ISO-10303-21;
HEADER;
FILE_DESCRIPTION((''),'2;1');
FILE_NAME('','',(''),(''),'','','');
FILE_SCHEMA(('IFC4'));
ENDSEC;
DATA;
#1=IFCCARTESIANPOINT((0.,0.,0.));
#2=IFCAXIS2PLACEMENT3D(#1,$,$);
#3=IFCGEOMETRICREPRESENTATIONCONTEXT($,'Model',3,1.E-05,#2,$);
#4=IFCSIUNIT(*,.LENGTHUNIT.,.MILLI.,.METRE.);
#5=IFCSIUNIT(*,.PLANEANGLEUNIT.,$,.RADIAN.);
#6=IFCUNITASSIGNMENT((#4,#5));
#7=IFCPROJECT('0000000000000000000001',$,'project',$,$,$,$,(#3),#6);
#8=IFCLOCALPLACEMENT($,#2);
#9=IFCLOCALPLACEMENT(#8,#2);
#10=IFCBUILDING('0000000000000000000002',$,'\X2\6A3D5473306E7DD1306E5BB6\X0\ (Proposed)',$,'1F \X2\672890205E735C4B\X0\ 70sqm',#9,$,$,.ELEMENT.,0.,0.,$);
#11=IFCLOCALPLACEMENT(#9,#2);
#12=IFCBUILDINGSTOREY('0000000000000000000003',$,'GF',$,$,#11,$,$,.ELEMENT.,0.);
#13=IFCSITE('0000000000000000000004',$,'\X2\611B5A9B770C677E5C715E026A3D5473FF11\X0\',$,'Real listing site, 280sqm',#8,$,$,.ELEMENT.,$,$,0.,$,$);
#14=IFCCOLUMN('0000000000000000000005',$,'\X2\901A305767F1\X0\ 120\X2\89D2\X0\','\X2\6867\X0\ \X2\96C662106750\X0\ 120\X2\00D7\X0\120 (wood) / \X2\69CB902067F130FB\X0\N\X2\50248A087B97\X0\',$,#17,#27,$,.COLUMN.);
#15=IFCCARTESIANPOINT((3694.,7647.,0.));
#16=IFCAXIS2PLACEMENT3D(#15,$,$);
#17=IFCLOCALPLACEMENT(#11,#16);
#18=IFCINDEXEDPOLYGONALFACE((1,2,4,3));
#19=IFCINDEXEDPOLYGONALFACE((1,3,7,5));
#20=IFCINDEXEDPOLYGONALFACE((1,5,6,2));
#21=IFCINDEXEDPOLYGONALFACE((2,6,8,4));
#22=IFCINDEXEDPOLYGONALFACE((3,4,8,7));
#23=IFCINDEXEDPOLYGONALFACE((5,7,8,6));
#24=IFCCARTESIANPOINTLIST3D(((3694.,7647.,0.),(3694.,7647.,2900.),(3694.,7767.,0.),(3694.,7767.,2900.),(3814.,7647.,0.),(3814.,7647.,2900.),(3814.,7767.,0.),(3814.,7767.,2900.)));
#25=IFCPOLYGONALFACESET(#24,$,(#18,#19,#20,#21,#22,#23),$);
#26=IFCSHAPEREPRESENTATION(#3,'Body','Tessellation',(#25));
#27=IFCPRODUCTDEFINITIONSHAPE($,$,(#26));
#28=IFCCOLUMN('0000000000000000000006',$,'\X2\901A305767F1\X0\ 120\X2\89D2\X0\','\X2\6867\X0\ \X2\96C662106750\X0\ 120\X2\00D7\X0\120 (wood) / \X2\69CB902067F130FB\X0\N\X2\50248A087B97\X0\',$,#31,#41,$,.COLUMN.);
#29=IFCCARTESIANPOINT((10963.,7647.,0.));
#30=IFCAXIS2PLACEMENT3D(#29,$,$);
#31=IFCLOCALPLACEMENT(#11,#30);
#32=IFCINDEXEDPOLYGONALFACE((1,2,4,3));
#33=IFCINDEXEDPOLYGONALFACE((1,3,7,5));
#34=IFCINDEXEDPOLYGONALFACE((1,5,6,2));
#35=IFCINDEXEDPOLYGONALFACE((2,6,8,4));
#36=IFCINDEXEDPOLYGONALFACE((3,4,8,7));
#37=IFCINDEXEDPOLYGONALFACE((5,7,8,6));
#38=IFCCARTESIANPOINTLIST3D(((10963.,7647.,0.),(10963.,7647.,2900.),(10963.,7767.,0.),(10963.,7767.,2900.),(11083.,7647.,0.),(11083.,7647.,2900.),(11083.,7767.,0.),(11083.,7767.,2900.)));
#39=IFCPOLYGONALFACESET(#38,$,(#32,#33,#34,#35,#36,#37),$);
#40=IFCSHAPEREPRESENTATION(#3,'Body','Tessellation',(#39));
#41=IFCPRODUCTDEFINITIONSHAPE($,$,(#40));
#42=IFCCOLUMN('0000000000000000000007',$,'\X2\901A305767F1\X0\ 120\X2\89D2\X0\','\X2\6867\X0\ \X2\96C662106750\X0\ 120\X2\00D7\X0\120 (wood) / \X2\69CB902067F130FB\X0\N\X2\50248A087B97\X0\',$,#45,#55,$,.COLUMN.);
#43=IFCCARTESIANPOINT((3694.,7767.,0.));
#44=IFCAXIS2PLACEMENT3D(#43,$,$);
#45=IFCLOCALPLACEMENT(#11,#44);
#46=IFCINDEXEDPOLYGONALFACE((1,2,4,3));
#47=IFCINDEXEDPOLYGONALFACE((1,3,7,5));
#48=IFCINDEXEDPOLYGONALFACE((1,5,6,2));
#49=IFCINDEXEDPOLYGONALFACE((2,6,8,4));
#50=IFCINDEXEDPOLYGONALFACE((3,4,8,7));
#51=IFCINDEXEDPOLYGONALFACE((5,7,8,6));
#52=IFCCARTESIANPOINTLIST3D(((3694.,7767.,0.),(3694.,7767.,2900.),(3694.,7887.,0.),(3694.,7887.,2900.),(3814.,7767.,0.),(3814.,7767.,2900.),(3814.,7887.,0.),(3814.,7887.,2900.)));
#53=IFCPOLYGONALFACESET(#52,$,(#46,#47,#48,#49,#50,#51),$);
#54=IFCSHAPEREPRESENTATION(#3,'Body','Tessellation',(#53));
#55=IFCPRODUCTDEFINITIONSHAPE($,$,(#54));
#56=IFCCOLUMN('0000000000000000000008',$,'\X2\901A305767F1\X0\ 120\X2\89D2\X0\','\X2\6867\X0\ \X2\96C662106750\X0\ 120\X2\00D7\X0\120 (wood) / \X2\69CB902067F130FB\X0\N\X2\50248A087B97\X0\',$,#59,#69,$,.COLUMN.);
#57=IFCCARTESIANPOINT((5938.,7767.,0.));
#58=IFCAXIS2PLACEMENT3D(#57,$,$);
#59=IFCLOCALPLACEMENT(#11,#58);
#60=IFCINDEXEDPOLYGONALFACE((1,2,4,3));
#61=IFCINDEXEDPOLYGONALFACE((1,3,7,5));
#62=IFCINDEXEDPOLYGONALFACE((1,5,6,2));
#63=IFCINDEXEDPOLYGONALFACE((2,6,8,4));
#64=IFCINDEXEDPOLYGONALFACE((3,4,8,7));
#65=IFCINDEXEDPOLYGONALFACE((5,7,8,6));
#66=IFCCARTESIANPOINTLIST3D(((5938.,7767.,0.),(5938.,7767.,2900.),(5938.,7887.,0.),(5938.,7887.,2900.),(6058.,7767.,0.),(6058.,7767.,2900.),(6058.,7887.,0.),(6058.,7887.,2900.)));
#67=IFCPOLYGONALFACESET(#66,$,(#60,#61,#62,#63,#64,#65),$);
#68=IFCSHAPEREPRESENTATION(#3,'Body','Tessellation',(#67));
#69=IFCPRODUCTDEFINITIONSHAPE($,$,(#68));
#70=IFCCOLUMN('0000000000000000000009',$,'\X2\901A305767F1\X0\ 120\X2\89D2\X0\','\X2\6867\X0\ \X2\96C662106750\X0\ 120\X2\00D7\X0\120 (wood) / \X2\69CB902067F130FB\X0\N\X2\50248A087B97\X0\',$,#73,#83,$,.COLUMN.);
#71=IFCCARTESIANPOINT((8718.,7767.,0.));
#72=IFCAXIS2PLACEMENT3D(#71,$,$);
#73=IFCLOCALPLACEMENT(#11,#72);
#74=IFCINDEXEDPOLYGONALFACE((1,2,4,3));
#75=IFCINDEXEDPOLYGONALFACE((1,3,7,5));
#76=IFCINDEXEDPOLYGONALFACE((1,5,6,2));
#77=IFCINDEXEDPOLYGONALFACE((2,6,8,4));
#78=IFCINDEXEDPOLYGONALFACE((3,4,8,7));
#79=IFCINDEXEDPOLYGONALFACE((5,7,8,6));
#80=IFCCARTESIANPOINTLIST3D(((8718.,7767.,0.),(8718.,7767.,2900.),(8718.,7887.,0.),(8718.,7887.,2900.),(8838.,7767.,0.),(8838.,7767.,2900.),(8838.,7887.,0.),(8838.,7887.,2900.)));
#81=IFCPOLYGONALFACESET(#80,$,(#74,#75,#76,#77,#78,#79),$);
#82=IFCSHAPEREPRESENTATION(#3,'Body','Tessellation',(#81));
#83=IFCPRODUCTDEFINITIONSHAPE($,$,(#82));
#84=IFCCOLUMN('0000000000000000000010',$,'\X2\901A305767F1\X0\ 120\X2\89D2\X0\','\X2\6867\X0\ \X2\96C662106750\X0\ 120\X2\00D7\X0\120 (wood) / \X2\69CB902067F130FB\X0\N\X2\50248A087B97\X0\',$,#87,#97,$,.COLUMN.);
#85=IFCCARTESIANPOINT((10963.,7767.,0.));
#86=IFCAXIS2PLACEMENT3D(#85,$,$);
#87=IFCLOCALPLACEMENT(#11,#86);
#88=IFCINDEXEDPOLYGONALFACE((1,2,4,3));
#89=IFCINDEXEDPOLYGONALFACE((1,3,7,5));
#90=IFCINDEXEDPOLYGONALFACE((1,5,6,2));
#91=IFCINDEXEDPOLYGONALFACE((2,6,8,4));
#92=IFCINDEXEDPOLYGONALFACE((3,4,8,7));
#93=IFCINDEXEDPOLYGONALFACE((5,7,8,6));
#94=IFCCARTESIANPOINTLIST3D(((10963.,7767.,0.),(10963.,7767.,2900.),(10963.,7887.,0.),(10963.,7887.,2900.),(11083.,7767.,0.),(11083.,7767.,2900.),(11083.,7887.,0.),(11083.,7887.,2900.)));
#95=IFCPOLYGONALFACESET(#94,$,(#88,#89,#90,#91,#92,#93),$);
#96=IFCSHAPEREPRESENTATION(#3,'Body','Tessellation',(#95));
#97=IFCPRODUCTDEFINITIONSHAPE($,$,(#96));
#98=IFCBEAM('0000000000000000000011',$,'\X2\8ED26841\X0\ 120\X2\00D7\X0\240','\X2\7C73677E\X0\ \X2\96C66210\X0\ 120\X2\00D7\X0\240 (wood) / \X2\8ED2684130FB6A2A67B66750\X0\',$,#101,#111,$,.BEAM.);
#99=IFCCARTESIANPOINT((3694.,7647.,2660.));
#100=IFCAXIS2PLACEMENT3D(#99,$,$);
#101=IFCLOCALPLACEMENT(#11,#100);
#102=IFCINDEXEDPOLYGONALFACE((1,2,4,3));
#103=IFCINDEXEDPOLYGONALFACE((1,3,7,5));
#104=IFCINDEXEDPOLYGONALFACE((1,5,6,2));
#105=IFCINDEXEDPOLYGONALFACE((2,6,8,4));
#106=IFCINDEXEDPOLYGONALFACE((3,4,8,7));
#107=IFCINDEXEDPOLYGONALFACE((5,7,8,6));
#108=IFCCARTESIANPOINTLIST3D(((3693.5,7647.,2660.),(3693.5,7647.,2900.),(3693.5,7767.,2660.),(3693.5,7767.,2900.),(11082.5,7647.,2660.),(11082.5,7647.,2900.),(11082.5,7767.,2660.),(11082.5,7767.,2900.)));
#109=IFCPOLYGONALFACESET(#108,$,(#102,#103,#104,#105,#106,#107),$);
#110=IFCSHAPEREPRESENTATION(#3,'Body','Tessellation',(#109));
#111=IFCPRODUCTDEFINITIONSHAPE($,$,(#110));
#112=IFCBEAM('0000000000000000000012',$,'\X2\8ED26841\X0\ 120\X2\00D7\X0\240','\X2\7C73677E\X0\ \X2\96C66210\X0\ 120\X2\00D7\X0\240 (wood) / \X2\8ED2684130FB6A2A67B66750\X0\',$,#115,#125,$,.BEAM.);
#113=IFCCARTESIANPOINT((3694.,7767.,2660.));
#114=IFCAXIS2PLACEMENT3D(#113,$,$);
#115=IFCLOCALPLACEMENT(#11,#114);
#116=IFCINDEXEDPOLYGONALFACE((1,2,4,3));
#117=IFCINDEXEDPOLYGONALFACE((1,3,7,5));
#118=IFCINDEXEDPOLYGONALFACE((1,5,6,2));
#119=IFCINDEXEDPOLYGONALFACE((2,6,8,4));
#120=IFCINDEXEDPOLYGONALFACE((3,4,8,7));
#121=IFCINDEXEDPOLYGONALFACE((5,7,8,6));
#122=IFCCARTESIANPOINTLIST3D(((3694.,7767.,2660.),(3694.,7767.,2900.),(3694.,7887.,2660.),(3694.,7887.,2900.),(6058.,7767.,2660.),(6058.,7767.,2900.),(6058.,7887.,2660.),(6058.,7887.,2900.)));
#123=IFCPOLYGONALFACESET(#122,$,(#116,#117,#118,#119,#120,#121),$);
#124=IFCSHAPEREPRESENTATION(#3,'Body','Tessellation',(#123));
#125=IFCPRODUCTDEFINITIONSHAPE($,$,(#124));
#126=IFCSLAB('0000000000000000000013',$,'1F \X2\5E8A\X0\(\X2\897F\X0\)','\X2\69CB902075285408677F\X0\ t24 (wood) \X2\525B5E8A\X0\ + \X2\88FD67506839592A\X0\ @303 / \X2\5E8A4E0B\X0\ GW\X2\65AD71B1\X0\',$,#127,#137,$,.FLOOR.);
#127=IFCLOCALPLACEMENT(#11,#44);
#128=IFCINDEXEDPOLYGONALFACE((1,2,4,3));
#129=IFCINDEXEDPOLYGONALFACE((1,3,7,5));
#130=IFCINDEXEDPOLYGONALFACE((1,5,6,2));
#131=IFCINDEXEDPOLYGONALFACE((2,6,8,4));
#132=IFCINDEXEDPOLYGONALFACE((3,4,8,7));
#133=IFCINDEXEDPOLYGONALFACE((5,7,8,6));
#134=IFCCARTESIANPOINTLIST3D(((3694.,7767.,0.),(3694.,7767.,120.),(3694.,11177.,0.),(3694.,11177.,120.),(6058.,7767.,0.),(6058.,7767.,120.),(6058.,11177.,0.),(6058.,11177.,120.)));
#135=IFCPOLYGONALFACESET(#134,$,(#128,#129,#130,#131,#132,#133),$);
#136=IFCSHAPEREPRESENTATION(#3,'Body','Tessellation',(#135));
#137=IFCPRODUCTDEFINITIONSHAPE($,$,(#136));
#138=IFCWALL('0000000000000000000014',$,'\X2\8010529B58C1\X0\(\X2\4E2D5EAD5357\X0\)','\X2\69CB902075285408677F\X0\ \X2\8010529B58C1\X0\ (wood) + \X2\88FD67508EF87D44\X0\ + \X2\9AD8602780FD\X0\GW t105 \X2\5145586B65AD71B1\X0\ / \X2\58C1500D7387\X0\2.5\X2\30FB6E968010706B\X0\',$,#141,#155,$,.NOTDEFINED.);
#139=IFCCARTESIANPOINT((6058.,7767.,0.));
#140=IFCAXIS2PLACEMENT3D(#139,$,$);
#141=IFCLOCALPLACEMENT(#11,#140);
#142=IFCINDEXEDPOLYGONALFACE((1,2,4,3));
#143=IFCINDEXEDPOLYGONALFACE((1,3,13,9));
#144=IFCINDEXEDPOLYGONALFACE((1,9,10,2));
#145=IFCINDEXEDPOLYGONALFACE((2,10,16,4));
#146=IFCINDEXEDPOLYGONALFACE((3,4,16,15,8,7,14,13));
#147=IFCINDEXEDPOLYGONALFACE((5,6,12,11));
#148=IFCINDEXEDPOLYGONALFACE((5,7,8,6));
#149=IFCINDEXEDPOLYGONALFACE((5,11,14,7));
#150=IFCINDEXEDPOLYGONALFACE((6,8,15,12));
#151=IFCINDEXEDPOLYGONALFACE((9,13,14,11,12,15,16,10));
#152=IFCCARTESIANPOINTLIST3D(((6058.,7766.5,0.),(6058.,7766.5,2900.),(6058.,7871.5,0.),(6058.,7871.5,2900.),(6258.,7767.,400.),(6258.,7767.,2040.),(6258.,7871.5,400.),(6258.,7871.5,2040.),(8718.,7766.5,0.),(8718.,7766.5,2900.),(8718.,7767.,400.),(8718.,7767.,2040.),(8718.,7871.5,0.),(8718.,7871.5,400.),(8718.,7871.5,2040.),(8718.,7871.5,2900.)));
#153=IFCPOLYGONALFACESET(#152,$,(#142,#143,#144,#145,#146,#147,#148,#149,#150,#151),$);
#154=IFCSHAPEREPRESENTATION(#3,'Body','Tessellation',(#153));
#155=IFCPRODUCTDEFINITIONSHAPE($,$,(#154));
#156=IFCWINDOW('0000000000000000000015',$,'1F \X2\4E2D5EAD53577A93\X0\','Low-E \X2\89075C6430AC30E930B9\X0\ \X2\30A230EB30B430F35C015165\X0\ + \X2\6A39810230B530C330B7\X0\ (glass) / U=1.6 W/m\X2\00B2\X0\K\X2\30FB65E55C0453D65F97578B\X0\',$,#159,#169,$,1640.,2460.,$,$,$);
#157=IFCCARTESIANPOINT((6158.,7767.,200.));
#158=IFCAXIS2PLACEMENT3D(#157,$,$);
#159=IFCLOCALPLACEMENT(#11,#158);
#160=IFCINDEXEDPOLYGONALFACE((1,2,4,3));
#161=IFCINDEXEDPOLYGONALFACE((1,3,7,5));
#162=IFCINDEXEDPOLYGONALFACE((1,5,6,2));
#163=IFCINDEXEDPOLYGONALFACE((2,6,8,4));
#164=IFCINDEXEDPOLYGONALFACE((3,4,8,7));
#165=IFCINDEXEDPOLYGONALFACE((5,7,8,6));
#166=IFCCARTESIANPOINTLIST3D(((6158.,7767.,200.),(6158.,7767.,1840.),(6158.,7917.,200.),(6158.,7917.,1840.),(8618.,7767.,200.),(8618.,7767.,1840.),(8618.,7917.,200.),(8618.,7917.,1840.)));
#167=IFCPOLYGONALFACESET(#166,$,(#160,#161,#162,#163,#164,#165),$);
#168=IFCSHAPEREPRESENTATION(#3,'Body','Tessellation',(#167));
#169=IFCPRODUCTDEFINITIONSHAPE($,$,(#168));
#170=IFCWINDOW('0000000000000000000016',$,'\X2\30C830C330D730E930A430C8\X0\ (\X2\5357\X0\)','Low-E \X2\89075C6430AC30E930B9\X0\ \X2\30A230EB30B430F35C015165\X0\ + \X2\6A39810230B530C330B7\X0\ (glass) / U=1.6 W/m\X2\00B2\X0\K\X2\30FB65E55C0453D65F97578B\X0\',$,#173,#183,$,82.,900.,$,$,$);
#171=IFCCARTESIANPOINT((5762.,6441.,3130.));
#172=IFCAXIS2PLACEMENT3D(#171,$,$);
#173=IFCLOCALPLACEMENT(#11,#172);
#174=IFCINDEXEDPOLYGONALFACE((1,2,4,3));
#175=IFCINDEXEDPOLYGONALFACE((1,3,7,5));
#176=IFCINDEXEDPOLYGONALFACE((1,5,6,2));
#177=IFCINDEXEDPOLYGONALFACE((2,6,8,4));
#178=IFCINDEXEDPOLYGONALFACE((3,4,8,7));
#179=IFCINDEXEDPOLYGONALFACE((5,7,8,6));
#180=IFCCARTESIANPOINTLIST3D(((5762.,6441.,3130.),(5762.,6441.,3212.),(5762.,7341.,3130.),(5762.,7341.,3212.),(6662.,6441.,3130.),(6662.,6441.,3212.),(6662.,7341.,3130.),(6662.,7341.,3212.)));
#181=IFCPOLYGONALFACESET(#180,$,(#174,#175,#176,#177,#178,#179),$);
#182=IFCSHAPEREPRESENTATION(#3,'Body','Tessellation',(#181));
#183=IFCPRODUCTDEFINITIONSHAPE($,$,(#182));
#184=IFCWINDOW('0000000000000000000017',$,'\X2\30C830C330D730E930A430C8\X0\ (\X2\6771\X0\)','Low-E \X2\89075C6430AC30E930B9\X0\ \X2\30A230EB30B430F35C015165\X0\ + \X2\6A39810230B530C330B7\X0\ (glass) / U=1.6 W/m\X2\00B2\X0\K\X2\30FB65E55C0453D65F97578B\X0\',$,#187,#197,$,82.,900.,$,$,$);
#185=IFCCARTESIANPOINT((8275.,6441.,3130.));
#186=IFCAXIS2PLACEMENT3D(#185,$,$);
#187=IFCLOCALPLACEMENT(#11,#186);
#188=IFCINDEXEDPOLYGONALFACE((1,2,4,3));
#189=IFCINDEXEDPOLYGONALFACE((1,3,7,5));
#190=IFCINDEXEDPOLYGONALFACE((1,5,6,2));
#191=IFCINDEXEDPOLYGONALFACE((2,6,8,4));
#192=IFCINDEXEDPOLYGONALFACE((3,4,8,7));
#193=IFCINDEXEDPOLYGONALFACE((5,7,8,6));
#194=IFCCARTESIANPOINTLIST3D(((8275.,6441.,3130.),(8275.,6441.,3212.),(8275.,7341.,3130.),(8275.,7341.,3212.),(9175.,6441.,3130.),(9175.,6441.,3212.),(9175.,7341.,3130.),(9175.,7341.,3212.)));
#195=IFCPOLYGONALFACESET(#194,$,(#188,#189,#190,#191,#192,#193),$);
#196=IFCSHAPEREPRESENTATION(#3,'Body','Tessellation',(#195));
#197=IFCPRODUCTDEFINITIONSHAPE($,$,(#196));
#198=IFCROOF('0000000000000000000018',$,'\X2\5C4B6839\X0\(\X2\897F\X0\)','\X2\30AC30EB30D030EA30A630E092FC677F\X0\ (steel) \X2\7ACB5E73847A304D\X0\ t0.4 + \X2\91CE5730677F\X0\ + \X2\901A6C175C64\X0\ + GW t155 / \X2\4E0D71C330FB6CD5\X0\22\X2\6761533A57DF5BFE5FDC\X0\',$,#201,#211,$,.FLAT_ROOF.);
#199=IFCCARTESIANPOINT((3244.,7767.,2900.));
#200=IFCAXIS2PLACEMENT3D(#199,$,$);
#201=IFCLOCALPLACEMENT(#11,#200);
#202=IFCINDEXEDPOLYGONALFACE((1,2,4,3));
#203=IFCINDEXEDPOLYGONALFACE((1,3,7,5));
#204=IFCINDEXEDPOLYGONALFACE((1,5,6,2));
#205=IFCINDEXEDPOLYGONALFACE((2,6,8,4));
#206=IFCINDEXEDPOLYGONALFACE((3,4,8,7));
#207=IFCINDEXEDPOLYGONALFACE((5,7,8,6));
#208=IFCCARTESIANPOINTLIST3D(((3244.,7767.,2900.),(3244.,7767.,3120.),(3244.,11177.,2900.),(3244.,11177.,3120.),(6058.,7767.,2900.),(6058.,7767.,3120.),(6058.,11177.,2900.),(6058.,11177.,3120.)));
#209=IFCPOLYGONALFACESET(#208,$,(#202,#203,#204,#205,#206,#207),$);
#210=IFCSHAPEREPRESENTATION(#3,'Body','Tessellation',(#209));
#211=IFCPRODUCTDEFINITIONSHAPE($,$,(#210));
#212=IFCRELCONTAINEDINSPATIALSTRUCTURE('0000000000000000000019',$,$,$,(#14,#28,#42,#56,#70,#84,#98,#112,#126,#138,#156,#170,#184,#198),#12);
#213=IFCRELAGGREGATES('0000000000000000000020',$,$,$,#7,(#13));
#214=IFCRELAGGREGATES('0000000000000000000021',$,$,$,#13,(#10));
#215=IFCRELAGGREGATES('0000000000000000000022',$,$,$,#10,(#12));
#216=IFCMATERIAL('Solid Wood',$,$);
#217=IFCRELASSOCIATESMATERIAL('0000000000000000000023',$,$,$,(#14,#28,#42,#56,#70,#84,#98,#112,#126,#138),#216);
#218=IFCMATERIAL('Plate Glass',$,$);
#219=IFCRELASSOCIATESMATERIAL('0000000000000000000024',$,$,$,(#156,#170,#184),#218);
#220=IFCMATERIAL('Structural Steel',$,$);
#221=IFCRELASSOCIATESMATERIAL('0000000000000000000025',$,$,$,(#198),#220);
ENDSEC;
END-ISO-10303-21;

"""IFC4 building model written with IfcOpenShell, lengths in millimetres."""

from ifc_helpers import new_model, si_unit, frame, frame_2d, origin, place, context, project, spatial, rectangle, extrude, material, element, fill, save


model = new_model("IFC4")

# Units and contexts
model_context = context("Model", 3, precision=1e-05, world=origin())
ifc_project = project(units=[si_unit("LENGTHUNIT", "METRE", prefix="MILLI"), si_unit("PLANEANGLEUNIT", "RADIAN")], contexts=[model_context])

# Site, building, storey
site_placement = place(None, origin())
site = spatial("IfcSite", under=ifc_project, at=site_placement, Name="愛媛県松山市樽味１", ObjectType="Real listing site, 280sqm", CompositionType="ELEMENT", RefElevation=0.0)
building_placement = place(site_placement, origin())
building = spatial("IfcBuilding", under=site, at=building_placement, Name="樽味の緑の家 (Proposed)", ObjectType="1F 木造平屋 70sqm", CompositionType="ELEMENT", ElevationOfRefHeight=0.0, ElevationOfTerrain=0.0)
storey_placement = place(building_placement, origin())
storey = spatial("IfcBuildingStorey", under=building, at=storey_placement, Name="GF", CompositionType="ELEMENT", Elevation=0.0)

# Columns
ifc_material_1 = material(Name="Solid Wood")
column_1_placement = place(storey_placement, frame((3694.0, 7647.0, 0.0)))
element("IfcColumn", 1, at=column_1_placement, inside=storey, material=ifc_material_1, Name="通し柱 120角", Description="桧 集成材 120×120 (wood) / 構造柱・N値計算", PredefinedType="COLUMN", context=model_context, shape_type="SweptSolid", body=[
    extrude(rectangle(XDim=120.0, YDim=120.0, at=frame_2d((60.0, 60.0))), frame((3694.0, 7647.0, 0.0)), (0.0, 0.0, 1.0), 2900.0),
])
column_2_placement = place(storey_placement, frame((10963.0, 7647.0, 0.0)))
element("IfcColumn", 2, at=column_2_placement, inside=storey, material=ifc_material_1, Name="通し柱 120角", Description="桧 集成材 120×120 (wood) / 構造柱・N値計算", PredefinedType="COLUMN", context=model_context, shape_type="SweptSolid", body=[
    extrude(rectangle(XDim=120.0, YDim=120.0, at=frame_2d((60.0, 60.0))), frame((10963.0, 7647.0, 0.0)), (0.0, 0.0, 1.0), 2900.0),
])
column_3_placement = place(storey_placement, frame((3694.0, 7767.0, 0.0)))
element("IfcColumn", 3, at=column_3_placement, inside=storey, material=ifc_material_1, Name="通し柱 120角", Description="桧 集成材 120×120 (wood) / 構造柱・N値計算", PredefinedType="COLUMN", context=model_context, shape_type="SweptSolid", body=[
    extrude(rectangle(XDim=120.0, YDim=120.0, at=frame_2d((60.0, 60.0))), frame((3694.0, 7767.0, 0.0)), (0.0, 0.0, 1.0), 2900.0),
])
column_4_placement = place(storey_placement, frame((5938.0, 7767.0, 0.0)))
element("IfcColumn", 4, at=column_4_placement, inside=storey, material=ifc_material_1, Name="通し柱 120角", Description="桧 集成材 120×120 (wood) / 構造柱・N値計算", PredefinedType="COLUMN", context=model_context, shape_type="SweptSolid", body=[
    extrude(rectangle(XDim=120.0, YDim=120.0, at=frame_2d((60.0, 60.0))), frame((5938.0, 7767.0, 0.0)), (0.0, 0.0, 1.0), 2900.0),
])
column_5_placement = place(storey_placement, frame((8718.0, 7767.0, 0.0)))
element("IfcColumn", 5, at=column_5_placement, inside=storey, material=ifc_material_1, Name="通し柱 120角", Description="桧 集成材 120×120 (wood) / 構造柱・N値計算", PredefinedType="COLUMN", context=model_context, shape_type="SweptSolid", body=[
    extrude(rectangle(XDim=120.0, YDim=120.0, at=frame_2d((60.0, 60.0))), frame((8718.0, 7767.0, 0.0)), (0.0, 0.0, 1.0), 2900.0),
])
column_6_placement = place(storey_placement, frame((10963.0, 7767.0, 0.0)))
element("IfcColumn", 6, at=column_6_placement, inside=storey, material=ifc_material_1, Name="通し柱 120角", Description="桧 集成材 120×120 (wood) / 構造柱・N値計算", PredefinedType="COLUMN", context=model_context, shape_type="SweptSolid", body=[
    extrude(rectangle(XDim=120.0, YDim=120.0, at=frame_2d((60.0, 60.0))), frame((10963.0, 7767.0, 0.0)), (0.0, 0.0, 1.0), 2900.0),
])

# Beams
beam_1_placement = place(storey_placement, frame((3694.0, 7647.0, 2660.0)))
element("IfcBeam", 7, at=beam_1_placement, inside=storey, material=ifc_material_1, Name="軒桁 120×240", Description="米松 集成 120×240 (wood) / 軒桁・横架材", PredefinedType="BEAM", context=model_context, shape_type="SweptSolid", body=[
    extrude(rectangle(XDim=7389.0, YDim=120.0, at=frame_2d((3694.0, 60.0))), frame((3694.0, 7647.0, 2660.0)), (0.0, 0.0, 1.0), 240.0),
])
beam_2_placement = place(storey_placement, frame((3694.0, 7767.0, 2660.0)))
element("IfcBeam", 8, at=beam_2_placement, inside=storey, material=ifc_material_1, Name="軒桁 120×240", Description="米松 集成 120×240 (wood) / 軒桁・横架材", PredefinedType="BEAM", context=model_context, shape_type="SweptSolid", body=[
    extrude(rectangle(XDim=2364.0, YDim=120.0, at=frame_2d((1182.0, 60.0))), frame((3694.0, 7767.0, 2660.0)), (0.0, 0.0, 1.0), 240.0),
])

# Slab
slab_1_placement = place(storey_placement, frame((3694.0, 7767.0, 0.0)))
element("IfcSlab", 9, at=slab_1_placement, inside=storey, material=ifc_material_1, Name="1F 床(西)", Description="構造用合板 t24 (wood) 剛床 + 製材根太 @303 / 床下 GW断熱", PredefinedType="FLOOR", context=model_context, shape_type="SweptSolid", body=[
    extrude(rectangle(XDim=2364.0, YDim=3410.0, at=frame_2d((1182.0, 1705.0))), frame((3694.0, 7767.0, 0.0)), (0.0, 0.0, 1.0), 120.0),
])

# Wall, opening, window
wall_1_placement = place(storey_placement, frame((6058.0, 7767.0, 0.0)))
wall_1 = element("IfcWall", 10, at=wall_1_placement, inside=storey, material=ifc_material_1, Name="耐力壁(中庭南)", Description="構造用合板 耐力壁 (wood) + 製材軸組 + 高性能GW t105 充填断熱 / 壁倍率2.5・準耐火", PredefinedType="NOTDEFINED", context=model_context, shape_type="SweptSolid", body=[
    extrude(rectangle(XDim=2660.0, YDim=105.0, at=frame_2d((1330.0, 52.0))), frame((6058.0, 7767.0, 0.0)), (0.0, 0.0, 1.0), 2900.0),
])
opening_placement = place(storey_placement, frame((6158.0, 7767.0, 200.0)))
opening = element("IfcOpeningElement", 11, at=opening_placement, cuts=wall_1, PredefinedType="NOTDEFINED", context=model_context, shape_type="SweptSolid", body=[
    extrude(rectangle(XDim=2460.0, YDim=150.0, at=frame_2d((1230.0, 75.0))), frame((6158.0, 7767.0, 200.0)), (0.0, 0.0, 1.0), 1640.0),
])
ifc_material_2 = material(Name="Plate Glass")
window_1_placement = place(storey_placement, frame((6158.0, 7767.0, 200.0)))
window_1 = element("IfcWindow", 12, at=window_1_placement, inside=storey, material=ifc_material_2, Name="1F 中庭南窓", Description="Low-E 複層ガラス アルゴン封入 + 樹脂サッシ (glass) / U=1.6 W/m²K・日射取得型", OverallHeight=1640.0, OverallWidth=2460.0, context=model_context, shape_type="SweptSolid", body=[
    extrude(rectangle(XDim=2460.0, YDim=150.0, at=frame_2d((1230.0, 75.0))), frame((6158.0, 7767.0, 200.0)), (0.0, 0.0, 1.0), 1640.0),
])
fill(opening, window_1)

# Windows
window_2_placement = place(storey_placement, frame((5762.0, 6441.0, 3130.0)))
element("IfcWindow", 13, at=window_2_placement, inside=storey, material=ifc_material_2, Name="トップライト (南)", Description="Low-E 複層ガラス アルゴン封入 + 樹脂サッシ (glass) / U=1.6 W/m²K・日射取得型", OverallHeight=82.0, OverallWidth=900.0, context=model_context, shape_type="SweptSolid", body=[
    extrude(rectangle(XDim=900.0, YDim=900.0, at=frame_2d((450.0, 450.0))), frame((5762.0, 6441.0, 3130.0)), (0.0, 0.0, 1.0), 82.0),
])
window_3_placement = place(storey_placement, frame((8275.0, 6441.0, 3130.0)))
element("IfcWindow", 14, at=window_3_placement, inside=storey, material=ifc_material_2, Name="トップライト (東)", Description="Low-E 複層ガラス アルゴン封入 + 樹脂サッシ (glass) / U=1.6 W/m²K・日射取得型", OverallHeight=82.0, OverallWidth=900.0, context=model_context, shape_type="SweptSolid", body=[
    extrude(rectangle(XDim=900.0, YDim=900.0, at=frame_2d((450.0, 450.0))), frame((8275.0, 6441.0, 3130.0)), (0.0, 0.0, 1.0), 82.0),
])

# Roof
ifc_material_3 = material(Name="Structural Steel")
roof_1_placement = place(storey_placement, frame((3244.0, 7767.0, 2900.0)))
element("IfcRoof", 15, at=roof_1_placement, inside=storey, material=ifc_material_3, Name="屋根(西)", Description="ガルバリウム鋼板 (steel) 立平葺き t0.4 + 野地板 + 通気層 + GW t155 / 不燃・法22条区域対応", PredefinedType="FLAT_ROOF", context=model_context, shape_type="SweptSolid", body=[
    extrude(rectangle(XDim=2814.0, YDim=3410.0, at=frame_2d((1407.0, 1705.0))), frame((3244.0, 7767.0, 2900.0)), (0.0, 0.0, 1.0), 220.0),
])

save(model, "model.ifc")
